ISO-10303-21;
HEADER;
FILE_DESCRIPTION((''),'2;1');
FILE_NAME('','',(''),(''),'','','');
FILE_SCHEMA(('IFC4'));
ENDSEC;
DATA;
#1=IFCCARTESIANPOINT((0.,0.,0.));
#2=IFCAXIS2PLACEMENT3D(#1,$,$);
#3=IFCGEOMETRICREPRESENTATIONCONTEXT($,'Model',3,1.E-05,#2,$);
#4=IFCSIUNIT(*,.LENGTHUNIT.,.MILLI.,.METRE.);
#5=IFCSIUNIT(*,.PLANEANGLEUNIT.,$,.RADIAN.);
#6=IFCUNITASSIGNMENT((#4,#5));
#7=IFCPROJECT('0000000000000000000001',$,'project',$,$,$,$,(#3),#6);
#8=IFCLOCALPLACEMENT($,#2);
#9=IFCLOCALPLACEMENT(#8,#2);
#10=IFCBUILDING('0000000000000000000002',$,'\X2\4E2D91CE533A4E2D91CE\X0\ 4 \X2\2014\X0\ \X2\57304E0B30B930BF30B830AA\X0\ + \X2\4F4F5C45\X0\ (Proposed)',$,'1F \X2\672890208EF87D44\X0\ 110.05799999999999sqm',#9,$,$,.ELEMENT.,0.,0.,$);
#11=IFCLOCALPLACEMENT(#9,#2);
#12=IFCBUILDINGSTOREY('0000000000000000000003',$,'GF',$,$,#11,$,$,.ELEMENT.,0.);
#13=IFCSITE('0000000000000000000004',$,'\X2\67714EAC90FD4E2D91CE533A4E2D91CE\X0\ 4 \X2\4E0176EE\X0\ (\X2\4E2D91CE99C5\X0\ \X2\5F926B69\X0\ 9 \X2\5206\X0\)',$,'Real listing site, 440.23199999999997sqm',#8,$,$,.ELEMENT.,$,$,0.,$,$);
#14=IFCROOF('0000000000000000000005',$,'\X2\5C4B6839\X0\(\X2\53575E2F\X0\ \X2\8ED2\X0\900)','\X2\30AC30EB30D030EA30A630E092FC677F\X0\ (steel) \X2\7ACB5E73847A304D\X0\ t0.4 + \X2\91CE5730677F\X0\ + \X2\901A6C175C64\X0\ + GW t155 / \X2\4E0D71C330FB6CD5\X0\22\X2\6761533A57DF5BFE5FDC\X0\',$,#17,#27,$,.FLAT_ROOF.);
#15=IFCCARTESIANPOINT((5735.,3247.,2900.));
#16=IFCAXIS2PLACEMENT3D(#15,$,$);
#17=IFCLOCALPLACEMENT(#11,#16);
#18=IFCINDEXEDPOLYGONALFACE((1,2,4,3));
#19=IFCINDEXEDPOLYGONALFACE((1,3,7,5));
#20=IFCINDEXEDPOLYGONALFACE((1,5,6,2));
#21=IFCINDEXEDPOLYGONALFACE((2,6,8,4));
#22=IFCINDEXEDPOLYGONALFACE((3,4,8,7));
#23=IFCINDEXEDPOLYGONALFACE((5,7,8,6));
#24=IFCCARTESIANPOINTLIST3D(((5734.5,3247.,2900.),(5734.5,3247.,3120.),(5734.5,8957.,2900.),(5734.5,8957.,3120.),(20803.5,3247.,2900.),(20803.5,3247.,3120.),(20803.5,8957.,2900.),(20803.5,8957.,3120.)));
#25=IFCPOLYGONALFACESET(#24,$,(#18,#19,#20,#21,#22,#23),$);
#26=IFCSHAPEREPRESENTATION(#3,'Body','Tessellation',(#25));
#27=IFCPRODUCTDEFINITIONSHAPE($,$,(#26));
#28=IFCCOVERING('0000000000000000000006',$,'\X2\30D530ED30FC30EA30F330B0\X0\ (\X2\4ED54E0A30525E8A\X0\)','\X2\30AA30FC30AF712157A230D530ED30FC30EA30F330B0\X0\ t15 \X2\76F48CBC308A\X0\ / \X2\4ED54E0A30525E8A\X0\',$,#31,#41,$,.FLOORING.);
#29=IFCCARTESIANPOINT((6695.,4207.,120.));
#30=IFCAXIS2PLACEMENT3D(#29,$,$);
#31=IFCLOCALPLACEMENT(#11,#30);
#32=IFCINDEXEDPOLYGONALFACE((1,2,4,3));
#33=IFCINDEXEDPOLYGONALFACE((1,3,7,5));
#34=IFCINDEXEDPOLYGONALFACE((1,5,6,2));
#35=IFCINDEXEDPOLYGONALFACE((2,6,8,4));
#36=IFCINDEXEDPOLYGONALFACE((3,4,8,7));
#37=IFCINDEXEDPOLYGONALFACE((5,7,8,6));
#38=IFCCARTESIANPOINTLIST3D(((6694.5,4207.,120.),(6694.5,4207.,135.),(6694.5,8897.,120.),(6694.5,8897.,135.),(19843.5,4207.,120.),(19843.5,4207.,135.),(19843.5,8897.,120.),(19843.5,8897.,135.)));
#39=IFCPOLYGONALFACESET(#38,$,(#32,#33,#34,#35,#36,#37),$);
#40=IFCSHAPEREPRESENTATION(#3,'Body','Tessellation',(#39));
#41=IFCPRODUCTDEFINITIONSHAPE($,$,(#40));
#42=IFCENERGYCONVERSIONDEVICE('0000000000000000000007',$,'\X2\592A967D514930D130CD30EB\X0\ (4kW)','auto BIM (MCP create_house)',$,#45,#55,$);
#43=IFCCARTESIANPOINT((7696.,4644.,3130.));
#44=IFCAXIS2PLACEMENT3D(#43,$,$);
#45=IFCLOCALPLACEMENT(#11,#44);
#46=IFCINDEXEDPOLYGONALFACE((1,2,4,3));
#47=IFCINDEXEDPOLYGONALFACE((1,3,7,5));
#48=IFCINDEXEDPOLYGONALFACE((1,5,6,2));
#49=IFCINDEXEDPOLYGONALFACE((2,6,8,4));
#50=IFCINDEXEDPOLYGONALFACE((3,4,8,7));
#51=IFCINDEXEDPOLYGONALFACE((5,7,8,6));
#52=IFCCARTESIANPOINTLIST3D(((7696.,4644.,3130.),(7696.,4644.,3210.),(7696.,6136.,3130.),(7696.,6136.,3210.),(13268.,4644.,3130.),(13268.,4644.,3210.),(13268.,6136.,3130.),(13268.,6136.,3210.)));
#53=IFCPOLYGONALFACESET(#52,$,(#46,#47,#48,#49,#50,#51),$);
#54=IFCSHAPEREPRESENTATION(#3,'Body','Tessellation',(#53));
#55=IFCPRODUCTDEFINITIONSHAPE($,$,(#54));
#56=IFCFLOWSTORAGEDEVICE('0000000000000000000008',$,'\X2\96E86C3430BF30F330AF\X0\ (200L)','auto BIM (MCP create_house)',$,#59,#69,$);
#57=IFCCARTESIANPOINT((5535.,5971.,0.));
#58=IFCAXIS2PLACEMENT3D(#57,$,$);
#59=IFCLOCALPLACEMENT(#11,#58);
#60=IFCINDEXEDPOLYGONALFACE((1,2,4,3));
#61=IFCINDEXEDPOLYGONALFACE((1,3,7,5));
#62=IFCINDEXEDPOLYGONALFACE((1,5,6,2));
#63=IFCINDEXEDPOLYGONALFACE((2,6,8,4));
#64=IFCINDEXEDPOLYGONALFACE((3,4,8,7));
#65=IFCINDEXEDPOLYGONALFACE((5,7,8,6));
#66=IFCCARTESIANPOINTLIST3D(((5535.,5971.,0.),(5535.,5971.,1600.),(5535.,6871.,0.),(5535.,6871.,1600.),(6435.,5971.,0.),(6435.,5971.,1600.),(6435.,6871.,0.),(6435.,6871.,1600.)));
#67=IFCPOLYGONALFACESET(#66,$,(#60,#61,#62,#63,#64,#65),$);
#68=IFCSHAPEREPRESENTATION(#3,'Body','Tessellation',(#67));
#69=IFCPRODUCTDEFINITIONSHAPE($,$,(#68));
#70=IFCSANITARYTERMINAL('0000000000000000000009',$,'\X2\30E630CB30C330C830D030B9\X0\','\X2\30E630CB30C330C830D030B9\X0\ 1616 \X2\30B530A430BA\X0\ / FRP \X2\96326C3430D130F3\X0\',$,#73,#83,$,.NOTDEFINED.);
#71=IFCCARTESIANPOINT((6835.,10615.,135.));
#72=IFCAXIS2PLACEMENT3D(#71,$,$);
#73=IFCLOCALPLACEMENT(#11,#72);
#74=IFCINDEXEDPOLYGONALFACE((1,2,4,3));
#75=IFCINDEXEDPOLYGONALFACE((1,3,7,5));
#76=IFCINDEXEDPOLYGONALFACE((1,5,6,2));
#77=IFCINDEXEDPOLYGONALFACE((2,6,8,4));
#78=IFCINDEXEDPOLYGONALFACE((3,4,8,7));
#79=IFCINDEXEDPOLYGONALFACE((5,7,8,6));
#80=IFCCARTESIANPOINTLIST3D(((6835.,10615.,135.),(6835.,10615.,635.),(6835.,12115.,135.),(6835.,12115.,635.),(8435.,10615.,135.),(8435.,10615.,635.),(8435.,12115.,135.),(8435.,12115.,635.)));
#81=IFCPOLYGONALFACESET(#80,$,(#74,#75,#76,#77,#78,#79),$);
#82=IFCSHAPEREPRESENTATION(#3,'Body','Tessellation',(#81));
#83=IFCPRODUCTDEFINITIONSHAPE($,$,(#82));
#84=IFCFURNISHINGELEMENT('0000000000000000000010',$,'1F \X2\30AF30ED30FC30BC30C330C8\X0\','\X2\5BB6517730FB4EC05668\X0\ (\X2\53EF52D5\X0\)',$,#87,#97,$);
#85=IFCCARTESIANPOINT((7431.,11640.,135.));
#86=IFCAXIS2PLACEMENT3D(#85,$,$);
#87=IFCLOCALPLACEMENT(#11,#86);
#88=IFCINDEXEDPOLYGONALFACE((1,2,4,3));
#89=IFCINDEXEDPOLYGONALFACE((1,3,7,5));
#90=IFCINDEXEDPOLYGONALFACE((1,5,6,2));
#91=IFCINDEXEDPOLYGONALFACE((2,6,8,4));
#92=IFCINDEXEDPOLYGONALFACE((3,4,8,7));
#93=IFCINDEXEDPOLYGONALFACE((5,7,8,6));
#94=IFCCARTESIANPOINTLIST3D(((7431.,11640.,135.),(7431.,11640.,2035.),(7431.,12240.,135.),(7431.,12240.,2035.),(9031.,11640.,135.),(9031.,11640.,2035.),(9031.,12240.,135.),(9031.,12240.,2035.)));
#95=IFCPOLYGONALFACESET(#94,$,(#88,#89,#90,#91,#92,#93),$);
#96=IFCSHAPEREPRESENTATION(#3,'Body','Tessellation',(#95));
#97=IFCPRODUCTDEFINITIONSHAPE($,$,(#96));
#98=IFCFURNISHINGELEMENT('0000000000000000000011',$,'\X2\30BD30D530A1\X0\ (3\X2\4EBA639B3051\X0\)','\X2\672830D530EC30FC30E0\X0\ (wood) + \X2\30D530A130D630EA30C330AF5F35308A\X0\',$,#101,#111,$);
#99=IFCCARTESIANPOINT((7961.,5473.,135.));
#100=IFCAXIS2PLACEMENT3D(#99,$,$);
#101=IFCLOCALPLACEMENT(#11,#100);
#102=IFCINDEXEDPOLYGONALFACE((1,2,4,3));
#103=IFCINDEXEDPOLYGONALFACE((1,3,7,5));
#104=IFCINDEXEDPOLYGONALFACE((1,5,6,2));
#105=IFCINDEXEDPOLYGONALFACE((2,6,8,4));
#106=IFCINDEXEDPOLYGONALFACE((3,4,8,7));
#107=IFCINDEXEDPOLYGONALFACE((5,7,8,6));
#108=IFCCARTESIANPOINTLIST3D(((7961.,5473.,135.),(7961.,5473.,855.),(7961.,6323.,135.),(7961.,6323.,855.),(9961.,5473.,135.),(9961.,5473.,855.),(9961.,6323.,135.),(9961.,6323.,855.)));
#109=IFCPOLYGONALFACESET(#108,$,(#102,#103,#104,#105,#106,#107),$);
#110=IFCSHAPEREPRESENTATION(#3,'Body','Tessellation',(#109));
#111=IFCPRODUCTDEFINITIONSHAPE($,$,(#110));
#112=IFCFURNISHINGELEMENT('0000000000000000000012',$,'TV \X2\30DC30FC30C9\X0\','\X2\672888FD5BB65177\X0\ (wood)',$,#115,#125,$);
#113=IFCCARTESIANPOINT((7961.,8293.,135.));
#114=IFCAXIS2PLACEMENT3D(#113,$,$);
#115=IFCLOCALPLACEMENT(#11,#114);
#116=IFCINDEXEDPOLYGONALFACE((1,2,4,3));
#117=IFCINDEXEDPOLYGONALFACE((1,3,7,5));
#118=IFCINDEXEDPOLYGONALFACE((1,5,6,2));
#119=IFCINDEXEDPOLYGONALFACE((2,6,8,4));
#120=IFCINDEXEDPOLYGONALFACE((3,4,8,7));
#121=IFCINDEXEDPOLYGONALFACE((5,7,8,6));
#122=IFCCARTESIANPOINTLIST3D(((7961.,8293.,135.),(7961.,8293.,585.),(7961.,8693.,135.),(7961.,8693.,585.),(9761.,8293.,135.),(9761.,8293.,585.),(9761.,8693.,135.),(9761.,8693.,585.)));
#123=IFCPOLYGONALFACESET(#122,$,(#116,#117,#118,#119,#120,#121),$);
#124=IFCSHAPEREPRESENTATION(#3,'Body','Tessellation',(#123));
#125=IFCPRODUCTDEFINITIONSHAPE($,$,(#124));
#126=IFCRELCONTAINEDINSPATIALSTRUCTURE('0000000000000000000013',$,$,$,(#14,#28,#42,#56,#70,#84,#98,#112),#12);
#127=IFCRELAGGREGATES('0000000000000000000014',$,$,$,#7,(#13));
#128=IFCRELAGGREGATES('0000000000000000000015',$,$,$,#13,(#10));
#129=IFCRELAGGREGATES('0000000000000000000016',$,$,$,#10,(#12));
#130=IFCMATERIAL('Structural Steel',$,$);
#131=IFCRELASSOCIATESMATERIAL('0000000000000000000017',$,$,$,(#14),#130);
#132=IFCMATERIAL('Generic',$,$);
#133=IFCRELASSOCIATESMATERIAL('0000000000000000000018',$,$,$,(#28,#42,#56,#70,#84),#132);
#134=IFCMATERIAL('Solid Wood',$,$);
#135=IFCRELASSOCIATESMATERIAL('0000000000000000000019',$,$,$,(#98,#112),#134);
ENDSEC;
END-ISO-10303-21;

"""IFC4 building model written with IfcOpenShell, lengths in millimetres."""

from ifc_helpers import new_model, si_unit, frame, frame_2d, origin, place, context, project, spatial, rectangle, extrude, material, element, save


model = new_model("IFC4")

# Units and contexts
model_context = context("Model", 3, precision=1e-05, world=origin())
ifc_project = project(units=[si_unit("LENGTHUNIT", "METRE", prefix="MILLI"), si_unit("PLANEANGLEUNIT", "RADIAN")], contexts=[model_context])

# Site, building, storey
site_placement = place(None, origin())
site = spatial("IfcSite", under=ifc_project, at=site_placement, Name="東京都中野区中野 4 丁目 (中野駅 徒歩 9 分)", ObjectType="Real listing site, 440.23199999999997sqm", CompositionType="ELEMENT", RefElevation=0.0)
building_placement = place(site_placement, origin())
building = spatial("IfcBuilding", under=site, at=building_placement, Name="中野区中野 4 — 地下スタジオ + 住居 (Proposed)", ObjectType="1F 木造軸組 110.05799999999999sqm", CompositionType="ELEMENT", ElevationOfRefHeight=0.0, ElevationOfTerrain=0.0)
storey_placement = place(building_placement, origin())
storey = spatial("IfcBuildingStorey", under=building, at=storey_placement, Name="GF", CompositionType="ELEMENT", Elevation=0.0)

# Shared definitions
ifc_material_1 = material(Name="Solid Wood")

# Roof
ifc_material_2 = material(Name="Structural Steel")
roof_1_placement = place(storey_placement, frame((5735.0, 3247.0, 2900.0)))
element("IfcRoof", 1, at=roof_1_placement, inside=storey, material=ifc_material_2, Name="屋根(南帯 軒900)", Description="ガルバリウム鋼板 (steel) 立平葺き t0.4 + 野地板 + 通気層 + GW t155 / 不燃・法22条区域対応", PredefinedType="FLAT_ROOF", context=model_context, shape_type="SweptSolid", body=[
    extrude(rectangle(XDim=15069.0, YDim=5710.0, at=frame_2d((7534.0, 2855.0))), frame((5735.0, 3247.0, 2900.0)), (0.0, 0.0, 1.0), 220.0),
])

# Covering
ifc_material_3 = material(Name="Generic")
covering_1_placement = place(storey_placement, frame((6695.0, 4207.0, 120.0)))
element("IfcCovering", 2, at=covering_1_placement, inside=storey, material=ifc_material_3, Name="フローリング (仕上げ床)", Description="オーク無垢フローリング t15 直貼り / 仕上げ床", PredefinedType="FLOORING", context=model_context, shape_type="SweptSolid", body=[
    extrude(rectangle(XDim=13149.0, YDim=4690.0, at=frame_2d((6574.0, 2345.0))), frame((6695.0, 4207.0, 120.0)), (0.0, 0.0, 1.0), 15.0),
])

# Energy conversion device
energy_conversion_device_placement = place(storey_placement, frame((7696.0, 4644.0, 3130.0)))
element("IfcEnergyConversionDevice", 3, at=energy_conversion_device_placement, inside=storey, material=ifc_material_3, Name="太陽光パネル (4kW)", Description="auto BIM (MCP create_house)", context=model_context, shape_type="SweptSolid", body=[
    extrude(rectangle(XDim=5572.0, YDim=1492.0, at=frame_2d((2786.0, 746.0))), frame((7696.0, 4644.0, 3130.0)), (0.0, 0.0, 1.0), 80.0),
])

# Flow storage device
flow_storage_device_placement = place(storey_placement, frame((5535.0, 5971.0, 0.0)))
element("IfcFlowStorageDevice", 4, at=flow_storage_device_placement, inside=storey, material=ifc_material_3, Name="雨水タンク (200L)", Description="auto BIM (MCP create_house)", context=model_context, shape_type="SweptSolid", body=[
    extrude(rectangle(XDim=900.0, YDim=900.0, at=frame_2d((450.0, 450.0))), frame((5535.0, 5971.0, 0.0)), (0.0, 0.0, 1.0), 1600.0),
])

# Sanitary terminal
sanitary_terminal_placement = place(storey_placement, frame((6835.0, 10615.0, 135.0)))
element("IfcSanitaryTerminal", 5, at=sanitary_terminal_placement, inside=storey, material=ifc_material_3, Name="ユニットバス", Description="ユニットバス 1616 サイズ / FRP 防水パン", PredefinedType="NOTDEFINED", context=model_context, shape_type="SweptSolid", body=[
    extrude(rectangle(XDim=1600.0, YDim=1500.0, at=frame_2d((800.0, 750.0))), frame((6835.0, 10615.0, 135.0)), (0.0, 0.0, 1.0), 500.0),
])

# Furnishing elements
furnishing_1_placement = place(storey_placement, frame((7431.0, 11640.0, 135.0)))
element("IfcFurnishingElement", 6, at=furnishing_1_placement, inside=storey, material=ifc_material_3, Name="1F クローゼット", Description="家具・什器 (可動)", context=model_context, shape_type="SweptSolid", body=[
    extrude(rectangle(XDim=1600.0, YDim=600.0, at=frame_2d((800.0, 300.0))), frame((7431.0, 11640.0, 135.0)), (0.0, 0.0, 1.0), 1900.0),
])
furnishing_2_placement = place(storey_placement, frame((7961.0, 5473.0, 135.0)))
element("IfcFurnishingElement", 7, at=furnishing_2_placement, inside=storey, material=ifc_material_1, Name="ソファ (3人掛け)", Description="木フレーム (wood) + ファブリック張り", context=model_context, shape_type="SweptSolid", body=[
    extrude(rectangle(XDim=2000.0, YDim=850.0, at=frame_2d((1000.0, 425.0))), frame((7961.0, 5473.0, 135.0)), (0.0, 0.0, 1.0), 720.0),
])
furnishing_3_placement = place(storey_placement, frame((7961.0, 8293.0, 135.0)))
element("IfcFurnishingElement", 8, at=furnishing_3_placement, inside=storey, material=ifc_material_1, Name="TV ボード", Description="木製家具 (wood)", context=model_context, shape_type="SweptSolid", body=[
    extrude(rectangle(XDim=1800.0, YDim=400.0, at=frame_2d((900.0, 200.0))), frame((7961.0, 8293.0, 135.0)), (0.0, 0.0, 1.0), 450.0),
])

save(model, "model.ifc")
